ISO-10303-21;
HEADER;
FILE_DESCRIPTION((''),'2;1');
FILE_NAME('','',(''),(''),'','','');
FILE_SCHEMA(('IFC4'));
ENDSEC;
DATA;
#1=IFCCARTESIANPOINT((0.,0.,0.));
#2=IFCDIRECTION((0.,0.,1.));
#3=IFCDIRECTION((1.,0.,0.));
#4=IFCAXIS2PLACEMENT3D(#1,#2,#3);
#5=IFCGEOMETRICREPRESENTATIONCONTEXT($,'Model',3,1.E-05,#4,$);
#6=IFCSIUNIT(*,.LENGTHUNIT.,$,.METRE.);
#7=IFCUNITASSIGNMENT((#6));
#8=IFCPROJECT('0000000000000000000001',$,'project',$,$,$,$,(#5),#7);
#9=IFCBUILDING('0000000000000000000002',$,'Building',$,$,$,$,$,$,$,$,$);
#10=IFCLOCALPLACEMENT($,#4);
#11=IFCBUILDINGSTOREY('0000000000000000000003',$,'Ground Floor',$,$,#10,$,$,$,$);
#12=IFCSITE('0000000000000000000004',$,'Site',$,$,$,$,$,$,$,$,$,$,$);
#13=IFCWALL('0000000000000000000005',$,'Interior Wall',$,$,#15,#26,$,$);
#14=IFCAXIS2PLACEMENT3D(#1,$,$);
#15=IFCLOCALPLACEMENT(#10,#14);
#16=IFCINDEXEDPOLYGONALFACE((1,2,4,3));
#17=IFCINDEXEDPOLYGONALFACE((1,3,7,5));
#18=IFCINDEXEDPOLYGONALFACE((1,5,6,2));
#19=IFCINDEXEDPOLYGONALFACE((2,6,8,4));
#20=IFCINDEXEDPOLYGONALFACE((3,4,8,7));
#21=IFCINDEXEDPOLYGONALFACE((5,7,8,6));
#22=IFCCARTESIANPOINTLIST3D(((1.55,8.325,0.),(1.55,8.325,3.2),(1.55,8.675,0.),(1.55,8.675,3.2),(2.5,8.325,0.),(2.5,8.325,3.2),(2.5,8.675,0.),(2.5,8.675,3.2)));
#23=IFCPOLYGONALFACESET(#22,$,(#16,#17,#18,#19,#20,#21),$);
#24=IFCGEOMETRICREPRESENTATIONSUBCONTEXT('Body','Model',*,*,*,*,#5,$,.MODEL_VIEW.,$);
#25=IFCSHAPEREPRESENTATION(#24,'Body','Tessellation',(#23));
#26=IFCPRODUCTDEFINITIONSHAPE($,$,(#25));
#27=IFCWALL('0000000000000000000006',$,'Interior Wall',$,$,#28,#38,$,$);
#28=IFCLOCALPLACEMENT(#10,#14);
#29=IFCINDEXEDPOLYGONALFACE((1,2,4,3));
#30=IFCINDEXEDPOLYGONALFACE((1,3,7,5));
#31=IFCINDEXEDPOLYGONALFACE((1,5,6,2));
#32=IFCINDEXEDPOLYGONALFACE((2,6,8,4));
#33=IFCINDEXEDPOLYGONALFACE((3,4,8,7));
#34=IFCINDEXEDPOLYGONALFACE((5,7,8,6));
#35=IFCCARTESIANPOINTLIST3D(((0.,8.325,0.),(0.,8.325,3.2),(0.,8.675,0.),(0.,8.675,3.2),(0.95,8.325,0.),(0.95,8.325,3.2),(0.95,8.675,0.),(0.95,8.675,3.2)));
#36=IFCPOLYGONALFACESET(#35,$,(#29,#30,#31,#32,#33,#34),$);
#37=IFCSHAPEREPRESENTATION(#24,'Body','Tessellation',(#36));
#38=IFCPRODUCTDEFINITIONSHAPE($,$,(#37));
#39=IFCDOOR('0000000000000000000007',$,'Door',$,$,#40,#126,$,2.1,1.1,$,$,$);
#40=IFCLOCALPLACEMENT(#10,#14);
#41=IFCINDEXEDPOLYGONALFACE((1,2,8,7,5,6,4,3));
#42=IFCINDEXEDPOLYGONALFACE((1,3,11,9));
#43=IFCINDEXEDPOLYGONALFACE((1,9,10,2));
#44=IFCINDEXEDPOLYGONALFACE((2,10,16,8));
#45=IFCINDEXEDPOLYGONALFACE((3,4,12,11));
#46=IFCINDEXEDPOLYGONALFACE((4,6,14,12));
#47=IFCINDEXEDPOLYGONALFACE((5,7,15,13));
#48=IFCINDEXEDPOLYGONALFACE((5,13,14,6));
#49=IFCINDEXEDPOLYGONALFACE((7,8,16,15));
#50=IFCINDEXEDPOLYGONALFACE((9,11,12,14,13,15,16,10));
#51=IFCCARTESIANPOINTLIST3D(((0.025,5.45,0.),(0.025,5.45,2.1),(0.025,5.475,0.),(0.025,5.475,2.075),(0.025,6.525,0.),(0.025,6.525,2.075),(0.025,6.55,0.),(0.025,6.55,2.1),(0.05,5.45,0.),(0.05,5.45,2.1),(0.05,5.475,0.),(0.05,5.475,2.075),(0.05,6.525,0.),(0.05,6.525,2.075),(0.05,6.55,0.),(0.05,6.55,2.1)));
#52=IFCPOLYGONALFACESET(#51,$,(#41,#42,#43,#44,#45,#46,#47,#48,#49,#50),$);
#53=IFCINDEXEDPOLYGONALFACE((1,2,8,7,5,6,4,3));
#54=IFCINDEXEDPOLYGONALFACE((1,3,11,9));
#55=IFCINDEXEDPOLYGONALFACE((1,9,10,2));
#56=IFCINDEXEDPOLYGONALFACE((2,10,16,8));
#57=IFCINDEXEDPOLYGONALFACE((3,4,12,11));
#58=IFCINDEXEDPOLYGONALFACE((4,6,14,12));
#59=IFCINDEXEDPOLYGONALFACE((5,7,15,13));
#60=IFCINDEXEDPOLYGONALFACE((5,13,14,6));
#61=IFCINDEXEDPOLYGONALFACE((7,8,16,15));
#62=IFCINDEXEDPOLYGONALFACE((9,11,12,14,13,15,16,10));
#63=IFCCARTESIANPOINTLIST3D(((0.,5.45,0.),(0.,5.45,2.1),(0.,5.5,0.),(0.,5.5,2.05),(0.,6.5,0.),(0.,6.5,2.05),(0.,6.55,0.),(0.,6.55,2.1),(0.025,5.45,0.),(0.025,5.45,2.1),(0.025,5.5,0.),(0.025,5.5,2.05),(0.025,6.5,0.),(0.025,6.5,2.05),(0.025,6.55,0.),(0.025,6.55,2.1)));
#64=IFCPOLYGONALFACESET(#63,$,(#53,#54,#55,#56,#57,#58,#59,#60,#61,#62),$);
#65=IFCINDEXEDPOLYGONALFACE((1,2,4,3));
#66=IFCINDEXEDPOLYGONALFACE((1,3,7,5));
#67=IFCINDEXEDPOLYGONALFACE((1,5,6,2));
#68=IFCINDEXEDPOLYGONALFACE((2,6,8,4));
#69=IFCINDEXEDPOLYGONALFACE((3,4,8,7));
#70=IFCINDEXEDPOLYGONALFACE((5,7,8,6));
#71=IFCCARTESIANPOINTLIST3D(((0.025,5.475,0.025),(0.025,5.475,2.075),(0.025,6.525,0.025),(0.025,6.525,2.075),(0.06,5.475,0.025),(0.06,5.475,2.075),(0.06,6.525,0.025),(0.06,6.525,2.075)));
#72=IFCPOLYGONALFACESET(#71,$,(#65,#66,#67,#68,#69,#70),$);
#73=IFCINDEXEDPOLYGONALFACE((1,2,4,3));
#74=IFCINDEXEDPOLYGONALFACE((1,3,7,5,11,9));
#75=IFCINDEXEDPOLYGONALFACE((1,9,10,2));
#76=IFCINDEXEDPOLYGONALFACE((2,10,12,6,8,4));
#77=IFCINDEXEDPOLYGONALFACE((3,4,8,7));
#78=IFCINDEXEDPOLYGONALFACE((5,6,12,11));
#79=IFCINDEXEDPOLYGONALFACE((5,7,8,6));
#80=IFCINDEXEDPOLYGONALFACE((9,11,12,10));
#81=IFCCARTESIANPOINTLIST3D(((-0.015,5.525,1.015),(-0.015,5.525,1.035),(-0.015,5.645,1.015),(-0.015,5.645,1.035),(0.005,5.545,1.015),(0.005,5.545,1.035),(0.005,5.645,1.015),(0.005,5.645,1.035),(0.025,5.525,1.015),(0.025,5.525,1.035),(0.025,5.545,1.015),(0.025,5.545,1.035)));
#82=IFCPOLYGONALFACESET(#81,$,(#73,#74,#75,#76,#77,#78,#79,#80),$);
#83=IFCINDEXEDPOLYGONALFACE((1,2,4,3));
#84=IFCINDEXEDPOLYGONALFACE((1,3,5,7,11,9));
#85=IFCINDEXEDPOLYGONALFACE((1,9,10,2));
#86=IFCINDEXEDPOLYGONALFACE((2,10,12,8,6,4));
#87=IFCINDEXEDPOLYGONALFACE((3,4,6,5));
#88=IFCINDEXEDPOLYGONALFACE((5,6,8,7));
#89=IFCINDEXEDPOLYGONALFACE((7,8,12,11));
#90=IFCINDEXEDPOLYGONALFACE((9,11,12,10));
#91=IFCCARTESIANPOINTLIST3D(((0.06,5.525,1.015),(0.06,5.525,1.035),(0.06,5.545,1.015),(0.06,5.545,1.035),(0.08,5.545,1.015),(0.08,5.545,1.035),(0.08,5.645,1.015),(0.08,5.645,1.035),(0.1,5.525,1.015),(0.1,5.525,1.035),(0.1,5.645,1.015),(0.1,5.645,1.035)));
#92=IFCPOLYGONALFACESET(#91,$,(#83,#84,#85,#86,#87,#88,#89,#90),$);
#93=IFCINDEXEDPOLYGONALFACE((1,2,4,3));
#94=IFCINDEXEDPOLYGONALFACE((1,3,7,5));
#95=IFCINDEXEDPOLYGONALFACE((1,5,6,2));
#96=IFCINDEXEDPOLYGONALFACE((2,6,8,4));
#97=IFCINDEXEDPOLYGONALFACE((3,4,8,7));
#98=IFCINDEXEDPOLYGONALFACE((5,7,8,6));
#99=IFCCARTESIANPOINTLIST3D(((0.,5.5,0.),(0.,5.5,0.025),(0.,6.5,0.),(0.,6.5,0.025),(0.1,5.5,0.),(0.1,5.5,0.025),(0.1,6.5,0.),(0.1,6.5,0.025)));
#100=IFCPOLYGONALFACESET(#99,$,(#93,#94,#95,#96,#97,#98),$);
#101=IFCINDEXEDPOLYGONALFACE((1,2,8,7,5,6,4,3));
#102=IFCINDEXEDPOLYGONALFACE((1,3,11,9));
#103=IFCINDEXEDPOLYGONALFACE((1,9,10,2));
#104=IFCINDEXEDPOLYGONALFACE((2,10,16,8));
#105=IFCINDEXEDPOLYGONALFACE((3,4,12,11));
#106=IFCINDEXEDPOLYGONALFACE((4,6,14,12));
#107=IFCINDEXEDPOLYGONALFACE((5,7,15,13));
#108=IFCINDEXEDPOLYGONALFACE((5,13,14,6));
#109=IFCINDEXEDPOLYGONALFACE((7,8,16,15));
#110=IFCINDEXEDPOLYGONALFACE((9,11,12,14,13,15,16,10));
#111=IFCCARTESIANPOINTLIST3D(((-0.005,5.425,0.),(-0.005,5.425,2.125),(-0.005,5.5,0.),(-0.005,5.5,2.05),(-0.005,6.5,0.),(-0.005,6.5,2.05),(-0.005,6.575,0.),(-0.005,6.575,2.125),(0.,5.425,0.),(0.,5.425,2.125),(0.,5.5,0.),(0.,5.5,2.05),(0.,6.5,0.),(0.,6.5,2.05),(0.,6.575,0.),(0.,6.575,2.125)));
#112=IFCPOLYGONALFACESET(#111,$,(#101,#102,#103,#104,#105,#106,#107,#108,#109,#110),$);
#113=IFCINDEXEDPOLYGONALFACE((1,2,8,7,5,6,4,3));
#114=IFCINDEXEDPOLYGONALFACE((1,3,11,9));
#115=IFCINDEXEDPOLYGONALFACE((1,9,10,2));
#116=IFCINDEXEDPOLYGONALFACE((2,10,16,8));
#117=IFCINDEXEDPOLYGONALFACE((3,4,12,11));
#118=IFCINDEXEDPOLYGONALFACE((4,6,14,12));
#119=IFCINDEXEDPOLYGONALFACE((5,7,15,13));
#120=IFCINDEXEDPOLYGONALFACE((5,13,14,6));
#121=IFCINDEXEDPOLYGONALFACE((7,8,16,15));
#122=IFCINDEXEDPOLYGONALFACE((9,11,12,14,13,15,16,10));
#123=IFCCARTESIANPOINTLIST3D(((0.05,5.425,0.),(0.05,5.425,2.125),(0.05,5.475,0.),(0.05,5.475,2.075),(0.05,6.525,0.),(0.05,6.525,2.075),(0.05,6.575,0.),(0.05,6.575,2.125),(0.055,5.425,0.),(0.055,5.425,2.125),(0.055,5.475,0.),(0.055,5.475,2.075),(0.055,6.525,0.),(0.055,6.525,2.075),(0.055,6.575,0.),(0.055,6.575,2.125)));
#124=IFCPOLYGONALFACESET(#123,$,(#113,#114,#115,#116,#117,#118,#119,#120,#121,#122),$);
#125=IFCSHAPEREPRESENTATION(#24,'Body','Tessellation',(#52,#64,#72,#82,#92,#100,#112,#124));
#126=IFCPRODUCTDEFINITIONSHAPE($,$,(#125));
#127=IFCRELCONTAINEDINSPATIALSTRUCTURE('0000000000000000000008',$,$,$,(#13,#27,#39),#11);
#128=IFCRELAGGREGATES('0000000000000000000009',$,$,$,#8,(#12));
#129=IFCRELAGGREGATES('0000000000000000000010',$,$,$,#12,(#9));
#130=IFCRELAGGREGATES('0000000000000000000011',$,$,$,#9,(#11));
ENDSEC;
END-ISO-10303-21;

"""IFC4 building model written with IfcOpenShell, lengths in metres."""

from ifc_helpers import new_model, si_unit, frame, origin_with_axes, place, context, subcontext, project, spatial, line, indexed_curve, outline, extrude, element, save


model = new_model("IFC4")

# Units and contexts
model_context = context("Model", 3, precision=1e-05, world=origin_with_axes())
body_context = subcontext(model_context, "Body", "Model", "MODEL_VIEW")
ifc_project = project(units=[si_unit("LENGTHUNIT", "METRE")], contexts=[model_context])

# Site, building, storey
site = spatial("IfcSite", under=ifc_project, Name="Site")
building = spatial("IfcBuilding", under=site, Name="Building")
storey_placement = place(None, origin_with_axes())
storey = spatial("IfcBuildingStorey", under=building, at=storey_placement, Name="Ground Floor")

# Walls
for number, where, z_axis, x_axis, name in (
    (1, (2.5, 8.5, 0.0), (0.0, 0.0, 1.0), (-1.0, 0.0, 0.0), "Interior Wall"),
    (2, (0.95, 8.5, 0.0), (0.0, 0.0, 1.0), (-1.0, 0.0, 0.0), "Interior Wall"),
):
    element("IfcWall", number, at=place(storey_placement, frame(where, z_axis=z_axis, x_axis=x_axis)), inside=storey, Name=name, context=body_context, shape_type="SweptSolid", body=[
        extrude(outline(indexed_curve([(0.0, 0.0), (0.0, 0.35), (0.95, 0.35), (0.95, 0.0), (0.0, 0.0)], self_intersect=False)), frame((0.0, -0.175, 0.0), z_axis=(0.0, 0.0, 1.0), x_axis=(1.0, 0.0, 0.0)), (0.0, 0.0, 1.0), 3.2),
    ])

# Door
door_1_placement = place(storey_placement, frame((0.0, 6.55, 0.0), z_axis=(0.0, 0.0, 1.0), x_axis=(0.0, -1.0, 0.0)))
element("IfcDoor", 3, at=door_1_placement, inside=storey, Name="Door", OverallHeight=2.1, OverallWidth=1.1, context=body_context, shape_type="SweptSolid", body=[
    extrude(outline(indexed_curve([(0.0, 0.0), (0.0, 2.1), (1.1, 2.1), (1.1, 0.0), (1.075, 0.0), (1.075, 2.075), (0.025, 2.075), (0.025, 0.0)], segments=[line(1, 2, 3, 4, 5, 6, 7, 8, 1)])), frame((0.0, 0.025, 0.0), z_axis=(0.0, -1.0, 0.0), x_axis=(1.0, 0.0, 0.0)), (0.0, 0.0, -1.0), 0.025),
    extrude(outline(indexed_curve([(0.0, 0.0), (0.0, 2.1), (1.1, 2.1), (1.1, 0.0), (1.05, 0.0), (1.05, 2.05), (0.05, 2.05), (0.05, 0.0)], segments=[line(1, 2, 3, 4, 5, 6, 7, 8, 1)])), frame((0.0, 0.0, 0.0), z_axis=(0.0, -1.0, 0.0), x_axis=(1.0, 0.0, 0.0)), (0.0, 0.0, -1.0), 0.025),
    extrude(outline(indexed_curve([(0.0, 0.0), (1.05, 0.0), (1.05, 0.035), (0.0, 0.035)], segments=[line(1, 2, 3, 4, 1)])), frame((0.025, 0.025, 0.025), z_axis=(0.0, 0.0, 1.0), x_axis=(1.0, 0.0, 0.0)), (0.0, 0.0, 1.0), 2.05),
    extrude(outline(indexed_curve([(0.0, 0.0), (0.0, -0.04), (-0.12, -0.04), (-0.12, -0.02), (-0.02, -0.02), (-0.02, 0.0)], segments=[line(1, 2, 3, 4, 5, 6, 1)])), frame((1.025, 0.025, 1.015), z_axis=(0.0, 0.0, 1.0), x_axis=(1.0, 0.0, 0.0)), (0.0, 0.0, 1.0), 0.02),
    extrude(outline(indexed_curve([(0.0, 0.0), (0.0, 0.04), (-0.12, 0.04), (-0.12, 0.02), (-0.02, 0.02), (-0.02, 0.0)], segments=[line(1, 2, 3, 4, 5, 6, 1)])), frame((1.025, 0.06, 1.015), z_axis=(0.0, 0.0, 1.0), x_axis=(1.0, 0.0, 0.0)), (0.0, 0.0, 1.0), 0.02),
    extrude(outline(indexed_curve([(0.0, 0.0), (1.0, 0.0), (1.0, 0.1), (0.0, 0.1)], segments=[line(1, 2, 3, 4, 1)])), frame((0.05, 0.0, 0.0), z_axis=(0.0, 0.0, 1.0), x_axis=(1.0, 0.0, 0.0)), (0.0, 0.0, 1.0), 0.025),
    extrude(outline(indexed_curve([(0.0, 0.0), (0.0, 2.125), (1.15, 2.125), (1.15, 0.0), (1.075, 0.0), (1.075, 2.05), (0.075, 2.05), (0.075, 0.0)], segments=[line(1, 2, 3, 4, 5, 6, 7, 8, 1)])), frame((-0.025, -0.005, 0.0), z_axis=(0.0, -1.0, 0.0), x_axis=(1.0, 0.0, 0.0)), (0.0, 0.0, -1.0), 0.005),
    extrude(outline(indexed_curve([(0.0, 0.0), (0.0, 2.125), (1.15, 2.125), (1.15, 0.0), (1.1, 0.0), (1.1, 2.075), (0.05, 2.075), (0.05, 0.0)], segments=[line(1, 2, 3, 4, 5, 6, 7, 8, 1)])), frame((-0.025, 0.05, 0.0), z_axis=(0.0, -1.0, 0.0), x_axis=(1.0, 0.0, 0.0)), (0.0, 0.0, -1.0), 0.005),
])

save(model, "model.ifc")
